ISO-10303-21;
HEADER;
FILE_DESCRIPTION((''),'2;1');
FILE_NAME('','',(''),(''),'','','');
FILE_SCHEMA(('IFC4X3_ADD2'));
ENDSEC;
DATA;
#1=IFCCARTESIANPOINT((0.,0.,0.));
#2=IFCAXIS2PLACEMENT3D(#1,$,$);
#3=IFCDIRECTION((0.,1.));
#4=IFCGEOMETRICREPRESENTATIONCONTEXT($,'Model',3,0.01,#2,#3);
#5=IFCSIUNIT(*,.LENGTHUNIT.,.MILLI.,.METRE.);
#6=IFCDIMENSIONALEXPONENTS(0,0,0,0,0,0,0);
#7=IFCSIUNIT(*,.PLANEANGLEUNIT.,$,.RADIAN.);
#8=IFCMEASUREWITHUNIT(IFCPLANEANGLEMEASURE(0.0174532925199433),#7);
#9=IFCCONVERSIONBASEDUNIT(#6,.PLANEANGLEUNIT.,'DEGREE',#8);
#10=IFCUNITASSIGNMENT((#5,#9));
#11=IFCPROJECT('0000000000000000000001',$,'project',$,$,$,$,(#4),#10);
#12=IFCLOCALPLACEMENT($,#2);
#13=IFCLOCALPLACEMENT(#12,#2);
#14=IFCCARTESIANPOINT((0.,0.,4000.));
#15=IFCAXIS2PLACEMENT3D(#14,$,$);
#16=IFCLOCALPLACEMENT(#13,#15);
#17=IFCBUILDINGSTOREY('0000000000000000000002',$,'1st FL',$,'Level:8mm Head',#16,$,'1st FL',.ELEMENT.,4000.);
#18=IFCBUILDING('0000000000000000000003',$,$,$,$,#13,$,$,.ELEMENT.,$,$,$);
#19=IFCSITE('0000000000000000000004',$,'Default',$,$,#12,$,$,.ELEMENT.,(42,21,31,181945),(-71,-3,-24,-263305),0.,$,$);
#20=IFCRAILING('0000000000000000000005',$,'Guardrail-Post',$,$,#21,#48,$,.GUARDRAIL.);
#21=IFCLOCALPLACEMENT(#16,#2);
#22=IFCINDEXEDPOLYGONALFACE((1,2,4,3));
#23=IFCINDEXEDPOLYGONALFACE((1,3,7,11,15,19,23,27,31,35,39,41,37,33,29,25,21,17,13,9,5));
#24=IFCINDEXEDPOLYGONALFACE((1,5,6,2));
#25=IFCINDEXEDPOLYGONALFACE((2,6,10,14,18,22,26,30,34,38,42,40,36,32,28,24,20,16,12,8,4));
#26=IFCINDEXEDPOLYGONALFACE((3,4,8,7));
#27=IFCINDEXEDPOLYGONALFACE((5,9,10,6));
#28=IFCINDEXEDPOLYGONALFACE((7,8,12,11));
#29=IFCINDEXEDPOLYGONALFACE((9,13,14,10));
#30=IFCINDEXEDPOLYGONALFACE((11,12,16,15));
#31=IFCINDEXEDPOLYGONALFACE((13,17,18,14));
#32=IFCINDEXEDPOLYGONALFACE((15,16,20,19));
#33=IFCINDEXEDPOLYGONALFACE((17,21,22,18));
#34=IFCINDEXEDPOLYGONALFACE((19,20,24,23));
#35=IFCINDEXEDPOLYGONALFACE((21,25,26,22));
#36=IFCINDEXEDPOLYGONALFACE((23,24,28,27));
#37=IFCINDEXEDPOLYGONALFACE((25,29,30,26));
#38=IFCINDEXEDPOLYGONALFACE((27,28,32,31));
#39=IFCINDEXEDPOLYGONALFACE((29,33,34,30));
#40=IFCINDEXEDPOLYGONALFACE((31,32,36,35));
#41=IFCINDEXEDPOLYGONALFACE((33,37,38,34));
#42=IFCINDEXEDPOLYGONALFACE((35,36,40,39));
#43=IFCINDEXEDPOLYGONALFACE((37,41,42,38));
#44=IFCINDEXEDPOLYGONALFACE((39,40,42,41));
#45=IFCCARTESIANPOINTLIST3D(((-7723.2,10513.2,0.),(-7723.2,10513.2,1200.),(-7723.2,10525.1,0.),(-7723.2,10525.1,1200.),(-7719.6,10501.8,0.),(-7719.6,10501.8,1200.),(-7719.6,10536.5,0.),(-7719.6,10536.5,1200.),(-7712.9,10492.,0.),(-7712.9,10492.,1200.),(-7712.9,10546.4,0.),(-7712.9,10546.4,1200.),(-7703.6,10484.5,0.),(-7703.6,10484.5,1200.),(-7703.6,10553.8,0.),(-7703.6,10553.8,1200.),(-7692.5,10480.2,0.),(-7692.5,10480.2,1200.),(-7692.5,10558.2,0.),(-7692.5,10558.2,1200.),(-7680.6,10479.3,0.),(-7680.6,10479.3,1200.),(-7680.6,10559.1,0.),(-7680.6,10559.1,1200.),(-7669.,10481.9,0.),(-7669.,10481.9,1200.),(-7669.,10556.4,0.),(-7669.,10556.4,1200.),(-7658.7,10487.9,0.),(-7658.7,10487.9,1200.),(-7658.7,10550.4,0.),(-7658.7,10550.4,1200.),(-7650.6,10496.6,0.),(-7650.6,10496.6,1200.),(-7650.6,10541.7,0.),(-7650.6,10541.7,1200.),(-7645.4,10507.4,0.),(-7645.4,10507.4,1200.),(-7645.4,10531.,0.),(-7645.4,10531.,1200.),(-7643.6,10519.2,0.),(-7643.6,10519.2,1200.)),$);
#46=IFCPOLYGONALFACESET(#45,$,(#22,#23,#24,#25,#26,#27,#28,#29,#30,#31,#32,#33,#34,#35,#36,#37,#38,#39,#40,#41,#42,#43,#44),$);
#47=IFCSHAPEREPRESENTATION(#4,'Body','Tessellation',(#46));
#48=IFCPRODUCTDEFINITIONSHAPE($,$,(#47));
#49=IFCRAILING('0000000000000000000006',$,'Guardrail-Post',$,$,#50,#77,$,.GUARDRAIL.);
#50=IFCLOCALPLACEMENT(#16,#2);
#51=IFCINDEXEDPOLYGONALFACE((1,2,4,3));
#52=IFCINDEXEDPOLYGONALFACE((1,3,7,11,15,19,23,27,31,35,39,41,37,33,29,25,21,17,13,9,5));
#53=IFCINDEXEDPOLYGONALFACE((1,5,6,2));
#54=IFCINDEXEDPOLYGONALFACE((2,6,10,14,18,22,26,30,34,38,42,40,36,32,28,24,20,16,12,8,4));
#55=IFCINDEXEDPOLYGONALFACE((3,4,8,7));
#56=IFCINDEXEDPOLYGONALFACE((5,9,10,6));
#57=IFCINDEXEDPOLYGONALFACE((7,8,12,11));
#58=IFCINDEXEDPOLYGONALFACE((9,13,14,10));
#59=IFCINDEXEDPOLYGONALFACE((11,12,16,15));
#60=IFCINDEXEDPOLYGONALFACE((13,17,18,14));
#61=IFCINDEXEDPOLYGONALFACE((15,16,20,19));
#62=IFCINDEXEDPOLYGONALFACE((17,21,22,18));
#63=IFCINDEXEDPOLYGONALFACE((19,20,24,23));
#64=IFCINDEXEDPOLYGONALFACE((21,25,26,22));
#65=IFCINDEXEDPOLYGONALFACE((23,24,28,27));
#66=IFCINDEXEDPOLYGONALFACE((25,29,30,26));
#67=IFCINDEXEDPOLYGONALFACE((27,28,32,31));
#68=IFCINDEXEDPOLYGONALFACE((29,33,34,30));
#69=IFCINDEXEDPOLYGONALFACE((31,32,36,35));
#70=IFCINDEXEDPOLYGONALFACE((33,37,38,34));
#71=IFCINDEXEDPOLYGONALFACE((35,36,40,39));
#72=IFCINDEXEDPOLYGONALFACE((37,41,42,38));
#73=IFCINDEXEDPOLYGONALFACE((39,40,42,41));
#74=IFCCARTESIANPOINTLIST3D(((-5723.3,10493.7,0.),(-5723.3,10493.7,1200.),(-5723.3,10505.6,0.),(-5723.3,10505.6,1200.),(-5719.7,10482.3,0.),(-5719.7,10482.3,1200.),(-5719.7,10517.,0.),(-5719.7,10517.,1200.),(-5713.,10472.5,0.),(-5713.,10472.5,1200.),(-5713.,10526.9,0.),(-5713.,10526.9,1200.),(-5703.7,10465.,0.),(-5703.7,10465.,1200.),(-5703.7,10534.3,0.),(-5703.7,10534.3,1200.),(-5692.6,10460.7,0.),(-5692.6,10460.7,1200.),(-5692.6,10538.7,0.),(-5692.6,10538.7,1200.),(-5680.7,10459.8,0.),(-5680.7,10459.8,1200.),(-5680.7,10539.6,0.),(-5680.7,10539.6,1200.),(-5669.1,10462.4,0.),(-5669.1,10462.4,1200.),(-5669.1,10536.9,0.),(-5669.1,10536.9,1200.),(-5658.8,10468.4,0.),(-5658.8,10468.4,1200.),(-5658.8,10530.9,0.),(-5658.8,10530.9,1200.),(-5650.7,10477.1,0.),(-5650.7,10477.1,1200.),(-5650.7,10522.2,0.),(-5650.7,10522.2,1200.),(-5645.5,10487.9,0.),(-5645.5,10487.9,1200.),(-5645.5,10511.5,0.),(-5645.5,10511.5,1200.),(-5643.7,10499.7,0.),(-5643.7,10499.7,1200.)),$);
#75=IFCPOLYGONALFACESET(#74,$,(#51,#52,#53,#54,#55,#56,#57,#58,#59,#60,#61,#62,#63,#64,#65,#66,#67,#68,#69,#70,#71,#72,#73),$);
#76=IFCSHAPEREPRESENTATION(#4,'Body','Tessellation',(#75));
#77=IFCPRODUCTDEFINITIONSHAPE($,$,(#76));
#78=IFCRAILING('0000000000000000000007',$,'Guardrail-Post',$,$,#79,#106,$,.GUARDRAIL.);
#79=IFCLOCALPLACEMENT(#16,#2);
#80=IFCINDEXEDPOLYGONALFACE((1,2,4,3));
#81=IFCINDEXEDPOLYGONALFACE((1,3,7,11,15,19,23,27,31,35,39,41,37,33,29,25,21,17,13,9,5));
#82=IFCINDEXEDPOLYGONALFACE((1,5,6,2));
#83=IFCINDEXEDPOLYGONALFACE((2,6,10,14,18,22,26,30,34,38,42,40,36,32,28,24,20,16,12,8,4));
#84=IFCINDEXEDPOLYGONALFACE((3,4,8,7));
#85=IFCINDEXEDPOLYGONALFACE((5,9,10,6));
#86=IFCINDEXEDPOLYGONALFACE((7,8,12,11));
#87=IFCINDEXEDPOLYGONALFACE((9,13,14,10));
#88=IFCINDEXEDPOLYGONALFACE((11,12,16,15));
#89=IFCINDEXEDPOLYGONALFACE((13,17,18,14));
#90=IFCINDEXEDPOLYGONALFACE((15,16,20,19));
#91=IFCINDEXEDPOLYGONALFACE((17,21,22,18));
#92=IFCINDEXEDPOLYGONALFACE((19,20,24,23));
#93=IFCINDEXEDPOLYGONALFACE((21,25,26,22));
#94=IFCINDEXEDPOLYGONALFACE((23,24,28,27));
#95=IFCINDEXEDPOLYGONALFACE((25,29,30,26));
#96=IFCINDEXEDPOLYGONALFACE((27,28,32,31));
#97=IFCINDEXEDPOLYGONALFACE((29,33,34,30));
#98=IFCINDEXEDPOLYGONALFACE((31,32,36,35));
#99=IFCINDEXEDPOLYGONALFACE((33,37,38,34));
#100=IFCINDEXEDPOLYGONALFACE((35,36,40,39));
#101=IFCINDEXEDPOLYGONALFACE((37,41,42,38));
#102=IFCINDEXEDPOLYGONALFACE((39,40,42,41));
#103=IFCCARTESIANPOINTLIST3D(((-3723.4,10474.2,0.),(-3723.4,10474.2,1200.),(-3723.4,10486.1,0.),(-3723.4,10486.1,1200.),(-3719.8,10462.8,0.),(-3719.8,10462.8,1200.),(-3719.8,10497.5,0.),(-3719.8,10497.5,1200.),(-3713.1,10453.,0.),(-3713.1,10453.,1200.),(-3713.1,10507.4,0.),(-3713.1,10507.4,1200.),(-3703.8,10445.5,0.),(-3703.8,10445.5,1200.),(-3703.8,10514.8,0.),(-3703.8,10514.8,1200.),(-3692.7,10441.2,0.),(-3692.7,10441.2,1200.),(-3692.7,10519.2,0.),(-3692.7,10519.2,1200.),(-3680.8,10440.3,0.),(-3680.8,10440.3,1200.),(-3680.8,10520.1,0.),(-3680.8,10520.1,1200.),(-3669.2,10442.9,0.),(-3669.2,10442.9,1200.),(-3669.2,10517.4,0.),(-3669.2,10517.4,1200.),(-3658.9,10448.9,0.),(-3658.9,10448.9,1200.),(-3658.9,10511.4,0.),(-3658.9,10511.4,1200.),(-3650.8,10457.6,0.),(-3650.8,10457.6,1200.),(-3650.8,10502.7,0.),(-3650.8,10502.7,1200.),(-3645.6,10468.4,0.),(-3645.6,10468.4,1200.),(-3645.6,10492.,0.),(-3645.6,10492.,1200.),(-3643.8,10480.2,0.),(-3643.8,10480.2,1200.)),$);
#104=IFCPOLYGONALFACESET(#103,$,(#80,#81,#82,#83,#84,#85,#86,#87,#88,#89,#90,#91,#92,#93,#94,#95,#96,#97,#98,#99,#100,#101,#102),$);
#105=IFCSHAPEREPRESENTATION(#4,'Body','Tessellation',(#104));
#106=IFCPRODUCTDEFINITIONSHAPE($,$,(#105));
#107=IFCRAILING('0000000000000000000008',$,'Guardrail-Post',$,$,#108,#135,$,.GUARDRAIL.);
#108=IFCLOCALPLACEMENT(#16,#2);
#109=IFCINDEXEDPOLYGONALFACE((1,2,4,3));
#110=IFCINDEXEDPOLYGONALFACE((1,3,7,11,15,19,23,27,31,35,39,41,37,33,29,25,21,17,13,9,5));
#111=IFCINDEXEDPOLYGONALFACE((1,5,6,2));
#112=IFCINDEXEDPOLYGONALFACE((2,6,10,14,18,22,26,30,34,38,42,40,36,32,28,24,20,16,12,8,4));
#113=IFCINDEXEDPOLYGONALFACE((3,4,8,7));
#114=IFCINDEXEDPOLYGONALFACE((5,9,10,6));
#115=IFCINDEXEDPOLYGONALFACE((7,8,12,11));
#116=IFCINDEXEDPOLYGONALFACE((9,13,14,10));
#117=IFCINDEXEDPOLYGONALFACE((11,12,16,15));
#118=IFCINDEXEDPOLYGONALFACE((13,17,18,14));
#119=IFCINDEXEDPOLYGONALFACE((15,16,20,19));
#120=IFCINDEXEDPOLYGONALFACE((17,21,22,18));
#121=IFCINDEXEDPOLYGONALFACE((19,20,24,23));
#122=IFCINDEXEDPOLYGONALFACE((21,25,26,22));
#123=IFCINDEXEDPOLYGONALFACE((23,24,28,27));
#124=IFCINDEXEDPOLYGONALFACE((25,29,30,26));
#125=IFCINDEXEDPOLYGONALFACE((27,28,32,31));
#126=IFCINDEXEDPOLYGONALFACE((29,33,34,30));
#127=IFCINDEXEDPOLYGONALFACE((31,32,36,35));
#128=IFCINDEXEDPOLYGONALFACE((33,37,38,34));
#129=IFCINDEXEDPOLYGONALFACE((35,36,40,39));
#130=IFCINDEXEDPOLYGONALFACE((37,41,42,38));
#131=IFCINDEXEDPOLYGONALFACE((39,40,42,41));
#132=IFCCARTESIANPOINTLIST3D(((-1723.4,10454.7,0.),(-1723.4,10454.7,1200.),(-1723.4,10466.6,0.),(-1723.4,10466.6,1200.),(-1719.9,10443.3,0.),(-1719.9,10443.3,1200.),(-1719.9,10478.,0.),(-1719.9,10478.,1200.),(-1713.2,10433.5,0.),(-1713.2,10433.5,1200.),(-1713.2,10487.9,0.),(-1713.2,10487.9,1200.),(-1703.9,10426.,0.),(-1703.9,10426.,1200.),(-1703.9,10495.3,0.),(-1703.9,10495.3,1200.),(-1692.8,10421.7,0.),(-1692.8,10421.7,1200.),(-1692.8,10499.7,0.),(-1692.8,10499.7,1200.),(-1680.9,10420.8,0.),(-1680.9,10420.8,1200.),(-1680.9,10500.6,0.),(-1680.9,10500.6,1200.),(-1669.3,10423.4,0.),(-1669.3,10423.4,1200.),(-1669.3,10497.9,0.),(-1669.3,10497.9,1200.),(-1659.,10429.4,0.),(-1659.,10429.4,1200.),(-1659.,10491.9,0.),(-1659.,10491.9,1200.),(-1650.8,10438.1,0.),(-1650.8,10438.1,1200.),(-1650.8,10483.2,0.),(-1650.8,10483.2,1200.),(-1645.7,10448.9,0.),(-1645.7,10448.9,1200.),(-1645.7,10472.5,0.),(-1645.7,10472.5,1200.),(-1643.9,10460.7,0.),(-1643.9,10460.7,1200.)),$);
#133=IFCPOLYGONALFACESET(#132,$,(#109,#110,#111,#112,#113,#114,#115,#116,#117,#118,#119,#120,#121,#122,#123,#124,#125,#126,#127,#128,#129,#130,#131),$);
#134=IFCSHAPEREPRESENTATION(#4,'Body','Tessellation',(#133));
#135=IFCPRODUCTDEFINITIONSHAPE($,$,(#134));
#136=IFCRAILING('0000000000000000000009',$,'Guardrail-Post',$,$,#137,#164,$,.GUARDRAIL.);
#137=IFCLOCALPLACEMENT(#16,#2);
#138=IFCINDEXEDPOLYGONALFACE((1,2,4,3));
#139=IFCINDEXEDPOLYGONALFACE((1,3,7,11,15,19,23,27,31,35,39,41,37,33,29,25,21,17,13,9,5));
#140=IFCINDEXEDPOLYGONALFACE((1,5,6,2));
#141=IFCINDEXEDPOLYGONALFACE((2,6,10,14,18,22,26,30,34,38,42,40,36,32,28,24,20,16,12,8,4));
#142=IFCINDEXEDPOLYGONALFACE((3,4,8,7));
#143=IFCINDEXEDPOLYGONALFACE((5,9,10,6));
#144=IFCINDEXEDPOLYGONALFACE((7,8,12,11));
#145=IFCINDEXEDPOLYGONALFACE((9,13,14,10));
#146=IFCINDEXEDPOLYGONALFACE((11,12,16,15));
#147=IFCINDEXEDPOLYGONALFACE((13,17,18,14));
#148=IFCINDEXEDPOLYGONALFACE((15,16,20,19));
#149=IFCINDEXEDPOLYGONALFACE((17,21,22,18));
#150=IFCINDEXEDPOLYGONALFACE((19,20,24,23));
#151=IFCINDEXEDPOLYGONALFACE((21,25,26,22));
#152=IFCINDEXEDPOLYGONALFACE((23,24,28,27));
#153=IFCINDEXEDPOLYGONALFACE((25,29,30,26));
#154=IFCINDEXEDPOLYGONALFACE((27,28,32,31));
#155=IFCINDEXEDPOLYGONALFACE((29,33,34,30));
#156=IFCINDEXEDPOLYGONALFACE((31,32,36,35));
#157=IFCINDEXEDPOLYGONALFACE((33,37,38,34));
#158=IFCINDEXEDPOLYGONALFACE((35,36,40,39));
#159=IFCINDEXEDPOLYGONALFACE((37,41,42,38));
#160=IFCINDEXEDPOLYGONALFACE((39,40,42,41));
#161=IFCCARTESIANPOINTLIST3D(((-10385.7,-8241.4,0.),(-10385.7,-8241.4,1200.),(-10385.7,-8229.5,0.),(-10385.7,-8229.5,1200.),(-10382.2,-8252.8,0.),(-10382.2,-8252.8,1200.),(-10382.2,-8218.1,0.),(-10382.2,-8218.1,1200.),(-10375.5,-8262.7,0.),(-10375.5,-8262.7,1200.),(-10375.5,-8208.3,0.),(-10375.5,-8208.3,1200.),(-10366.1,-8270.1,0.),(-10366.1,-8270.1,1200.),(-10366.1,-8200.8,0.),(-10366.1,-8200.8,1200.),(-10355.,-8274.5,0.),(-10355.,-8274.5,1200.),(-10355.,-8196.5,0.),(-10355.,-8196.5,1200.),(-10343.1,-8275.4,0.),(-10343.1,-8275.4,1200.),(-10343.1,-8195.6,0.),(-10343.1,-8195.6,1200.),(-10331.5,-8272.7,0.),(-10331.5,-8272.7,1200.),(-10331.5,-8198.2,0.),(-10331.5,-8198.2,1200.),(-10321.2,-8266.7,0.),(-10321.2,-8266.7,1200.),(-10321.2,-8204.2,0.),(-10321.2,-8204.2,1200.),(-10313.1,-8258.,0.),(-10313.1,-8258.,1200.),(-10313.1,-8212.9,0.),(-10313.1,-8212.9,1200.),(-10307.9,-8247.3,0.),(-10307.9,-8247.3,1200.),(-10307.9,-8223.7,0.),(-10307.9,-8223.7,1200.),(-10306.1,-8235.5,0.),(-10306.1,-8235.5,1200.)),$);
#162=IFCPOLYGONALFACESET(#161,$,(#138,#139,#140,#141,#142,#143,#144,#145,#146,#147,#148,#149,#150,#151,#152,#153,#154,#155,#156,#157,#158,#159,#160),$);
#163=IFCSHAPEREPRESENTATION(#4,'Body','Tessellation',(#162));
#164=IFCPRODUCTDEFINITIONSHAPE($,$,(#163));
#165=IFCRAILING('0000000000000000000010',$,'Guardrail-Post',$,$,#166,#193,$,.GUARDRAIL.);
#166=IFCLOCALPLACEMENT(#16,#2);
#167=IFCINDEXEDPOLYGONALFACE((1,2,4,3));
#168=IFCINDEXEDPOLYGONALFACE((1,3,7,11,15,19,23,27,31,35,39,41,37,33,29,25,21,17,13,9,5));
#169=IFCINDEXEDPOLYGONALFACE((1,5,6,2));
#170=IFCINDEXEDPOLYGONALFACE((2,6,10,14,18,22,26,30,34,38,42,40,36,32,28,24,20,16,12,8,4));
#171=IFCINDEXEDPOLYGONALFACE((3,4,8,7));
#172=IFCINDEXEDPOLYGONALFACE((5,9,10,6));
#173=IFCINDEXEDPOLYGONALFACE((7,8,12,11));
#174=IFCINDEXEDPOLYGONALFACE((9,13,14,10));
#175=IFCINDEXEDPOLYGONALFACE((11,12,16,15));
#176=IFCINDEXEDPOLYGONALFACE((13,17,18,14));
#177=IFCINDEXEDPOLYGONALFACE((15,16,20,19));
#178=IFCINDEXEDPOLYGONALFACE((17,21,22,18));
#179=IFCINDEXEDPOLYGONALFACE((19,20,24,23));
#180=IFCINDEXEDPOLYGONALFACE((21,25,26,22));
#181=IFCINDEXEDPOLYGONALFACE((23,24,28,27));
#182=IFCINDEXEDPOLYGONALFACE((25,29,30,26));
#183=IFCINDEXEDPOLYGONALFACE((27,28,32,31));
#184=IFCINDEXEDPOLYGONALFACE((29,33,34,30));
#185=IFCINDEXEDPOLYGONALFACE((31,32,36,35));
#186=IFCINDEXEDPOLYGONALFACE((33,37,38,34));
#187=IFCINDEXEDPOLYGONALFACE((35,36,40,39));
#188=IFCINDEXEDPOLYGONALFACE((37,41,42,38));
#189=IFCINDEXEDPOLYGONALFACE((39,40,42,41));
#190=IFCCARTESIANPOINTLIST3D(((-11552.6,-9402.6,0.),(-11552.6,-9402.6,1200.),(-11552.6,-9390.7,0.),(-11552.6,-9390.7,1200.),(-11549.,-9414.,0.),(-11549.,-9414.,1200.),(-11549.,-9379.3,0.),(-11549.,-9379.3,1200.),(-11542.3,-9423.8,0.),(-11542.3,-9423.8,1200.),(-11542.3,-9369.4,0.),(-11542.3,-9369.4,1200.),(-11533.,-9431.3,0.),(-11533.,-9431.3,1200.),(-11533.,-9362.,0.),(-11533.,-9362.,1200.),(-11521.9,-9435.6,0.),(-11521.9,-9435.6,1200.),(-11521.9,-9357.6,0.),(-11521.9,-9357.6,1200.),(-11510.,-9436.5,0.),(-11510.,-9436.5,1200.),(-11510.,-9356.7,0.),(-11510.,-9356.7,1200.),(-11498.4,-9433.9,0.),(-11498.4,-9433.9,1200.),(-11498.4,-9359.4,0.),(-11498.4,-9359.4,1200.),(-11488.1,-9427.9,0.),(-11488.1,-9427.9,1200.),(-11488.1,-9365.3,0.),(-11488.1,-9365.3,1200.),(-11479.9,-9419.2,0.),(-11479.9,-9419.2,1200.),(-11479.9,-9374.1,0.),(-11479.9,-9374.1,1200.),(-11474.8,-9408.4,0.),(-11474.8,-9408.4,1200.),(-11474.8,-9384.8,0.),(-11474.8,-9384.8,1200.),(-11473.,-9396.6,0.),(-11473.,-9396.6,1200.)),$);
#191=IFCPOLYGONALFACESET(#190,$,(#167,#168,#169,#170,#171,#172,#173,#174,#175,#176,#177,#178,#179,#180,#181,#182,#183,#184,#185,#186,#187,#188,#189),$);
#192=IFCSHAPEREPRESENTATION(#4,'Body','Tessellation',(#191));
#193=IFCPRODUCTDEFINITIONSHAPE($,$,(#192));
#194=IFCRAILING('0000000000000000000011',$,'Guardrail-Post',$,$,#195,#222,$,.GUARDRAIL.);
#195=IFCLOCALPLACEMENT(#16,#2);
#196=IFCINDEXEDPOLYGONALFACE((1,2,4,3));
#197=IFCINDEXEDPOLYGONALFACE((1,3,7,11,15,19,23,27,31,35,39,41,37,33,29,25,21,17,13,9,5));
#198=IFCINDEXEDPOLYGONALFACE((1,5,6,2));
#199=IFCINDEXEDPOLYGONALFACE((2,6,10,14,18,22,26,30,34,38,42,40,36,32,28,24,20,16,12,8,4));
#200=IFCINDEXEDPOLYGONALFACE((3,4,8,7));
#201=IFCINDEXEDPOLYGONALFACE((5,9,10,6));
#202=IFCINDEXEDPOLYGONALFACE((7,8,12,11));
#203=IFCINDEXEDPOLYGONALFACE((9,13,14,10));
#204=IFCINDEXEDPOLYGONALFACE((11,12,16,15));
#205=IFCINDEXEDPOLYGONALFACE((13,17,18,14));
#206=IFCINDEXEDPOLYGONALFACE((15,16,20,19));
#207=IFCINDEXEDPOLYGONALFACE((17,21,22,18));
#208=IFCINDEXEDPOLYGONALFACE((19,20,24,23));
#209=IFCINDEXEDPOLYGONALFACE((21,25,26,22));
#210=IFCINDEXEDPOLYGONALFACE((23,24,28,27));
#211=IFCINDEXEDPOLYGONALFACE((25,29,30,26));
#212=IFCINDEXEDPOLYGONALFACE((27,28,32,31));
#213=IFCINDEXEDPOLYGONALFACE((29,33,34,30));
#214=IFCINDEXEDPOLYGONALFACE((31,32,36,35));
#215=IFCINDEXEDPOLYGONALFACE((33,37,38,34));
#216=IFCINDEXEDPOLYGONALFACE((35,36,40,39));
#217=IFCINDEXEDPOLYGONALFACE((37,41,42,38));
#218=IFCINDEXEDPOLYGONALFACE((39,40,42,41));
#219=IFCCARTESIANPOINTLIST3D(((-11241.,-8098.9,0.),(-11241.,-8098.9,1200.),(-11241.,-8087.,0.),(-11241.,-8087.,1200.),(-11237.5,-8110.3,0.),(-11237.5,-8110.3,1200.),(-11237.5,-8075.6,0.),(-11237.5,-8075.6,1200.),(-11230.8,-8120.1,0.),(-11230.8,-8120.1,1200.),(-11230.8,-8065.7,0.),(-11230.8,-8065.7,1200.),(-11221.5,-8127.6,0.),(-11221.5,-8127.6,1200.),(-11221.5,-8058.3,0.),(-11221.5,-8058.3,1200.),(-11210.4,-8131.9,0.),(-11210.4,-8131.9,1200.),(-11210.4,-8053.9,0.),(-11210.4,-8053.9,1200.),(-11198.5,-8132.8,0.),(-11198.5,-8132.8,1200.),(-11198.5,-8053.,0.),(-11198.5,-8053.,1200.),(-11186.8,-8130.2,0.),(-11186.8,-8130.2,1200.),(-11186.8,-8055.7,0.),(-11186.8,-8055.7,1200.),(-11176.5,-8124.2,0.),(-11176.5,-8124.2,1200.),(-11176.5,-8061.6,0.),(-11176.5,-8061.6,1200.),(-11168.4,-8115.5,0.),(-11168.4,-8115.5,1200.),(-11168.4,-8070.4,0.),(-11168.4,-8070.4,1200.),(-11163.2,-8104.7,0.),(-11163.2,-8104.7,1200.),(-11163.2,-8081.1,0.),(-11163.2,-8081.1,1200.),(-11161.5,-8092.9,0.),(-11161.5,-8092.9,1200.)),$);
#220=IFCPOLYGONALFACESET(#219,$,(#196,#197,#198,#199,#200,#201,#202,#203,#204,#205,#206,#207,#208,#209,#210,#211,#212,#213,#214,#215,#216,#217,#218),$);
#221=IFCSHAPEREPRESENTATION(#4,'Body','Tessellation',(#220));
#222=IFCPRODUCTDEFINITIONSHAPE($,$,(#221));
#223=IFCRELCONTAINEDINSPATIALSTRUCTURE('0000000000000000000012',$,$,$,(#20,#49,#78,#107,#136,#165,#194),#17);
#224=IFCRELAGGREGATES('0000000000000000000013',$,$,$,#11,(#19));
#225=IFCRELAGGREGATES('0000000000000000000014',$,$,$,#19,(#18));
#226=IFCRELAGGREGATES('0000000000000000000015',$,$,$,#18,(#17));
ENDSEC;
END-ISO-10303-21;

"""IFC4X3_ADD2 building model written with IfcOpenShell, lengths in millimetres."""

from ifc_helpers import new_model, entity, si_unit, converted_unit, direction, frame, origin, origin_with_axes, origin_2d, place, context, project, spatial, circle, extrude, element, save


model = new_model("IFC4X3_ADD2")

# Units and contexts
model_context = context("Model", 3, precision=0.01, world=origin(), true_north=direction((0.0, 1.0)))
ifc_project = project(units=[si_unit("LENGTHUNIT", "METRE", prefix="MILLI"), converted_unit("PLANEANGLEUNIT", "DEGREE", entity("IfcPlaneAngleMeasure", 0.0174532925199433), si_unit("PLANEANGLEUNIT", "RADIAN"), dimensions=[0, 0, 0, 0, 0, 0, 0])], contexts=[model_context])

# Site, building, storey
site_placement = place(None, origin())
site = spatial("IfcSite", under=ifc_project, at=site_placement, Name="Default", CompositionType="ELEMENT", RefLatitude=(42, 21, 31, 181945), RefLongitude=(-71, -3, -24, -263305), RefElevation=0.0)
building_placement = place(site_placement, origin())
building = spatial("IfcBuilding", under=site, at=building_placement, CompositionType="ELEMENT")
storey_placement = place(building_placement, frame((0.0, 0.0, 4000.0)))
storey = spatial("IfcBuildingStorey", under=building, at=storey_placement, Name="1st FL", ObjectType="Level:8mm Head", LongName="1st FL", CompositionType="ELEMENT", Elevation=4000.0)

# Railings
for number, where, z_axis, x_axis, name in (
    (1, (-7683.6, 10519.2, 4000.0), (0.0, 0.0, 1.0), (1.0, 0.0, 0.0), "Guardrail-Post"),
    (2, (-5683.7, 10499.7, 4000.0), (0.0, 0.0, 1.0), (1.0, 0.0, 0.0), "Guardrail-Post"),
    (3, (-3683.8, 10480.2, 4000.0), (0.0, 0.0, 1.0), (1.0, 0.0, 0.0), "Guardrail-Post"),
    (4, (-1683.9, 10460.7, 4000.0), (0.0, 0.0, 1.0), (1.0, 0.0, 0.0), "Guardrail-Post"),
):
    element("IfcRailing", number, at=place(None, frame(where, z_axis=z_axis, x_axis=x_axis)), inside=storey, Name=name, PredefinedType="GUARDRAIL", context=model_context, shape_type="SweptSolid", body=[
        extrude(circle(Radius=40.0, at=origin_2d()), origin_with_axes(), (0.0, 0.0, 1.0), 1200.0),
    ])
for number, where, z_axis, x_axis, name in (
    (5, (-10346.1, -8235.5, 4000.0), (0.0, 0.0, 1.0), (1.0, 0.0, 0.0), "Guardrail-Post"),
    (6, (-11513.0, -9396.6, 4000.0), (0.0, 0.0, 1.0), (1.0, 0.0, 0.0), "Guardrail-Post"),
    (7, (-11201.5, -8092.9, 4000.0), (0.0, 0.0, 1.0), (1.0, 0.0, 0.0), "Guardrail-Post"),
):
    element("IfcRailing", number, at=place(None, frame(where, z_axis=z_axis, x_axis=x_axis)), inside=storey, Name=name, PredefinedType="GUARDRAIL", context=model_context, shape_type="SweptSolid", body=[
        extrude(circle(Radius=40.0, at=origin_2d()), origin_with_axes(), (0.0, 0.0, 1.0), 1200.0),
    ])

save(model, "model.ifc")
